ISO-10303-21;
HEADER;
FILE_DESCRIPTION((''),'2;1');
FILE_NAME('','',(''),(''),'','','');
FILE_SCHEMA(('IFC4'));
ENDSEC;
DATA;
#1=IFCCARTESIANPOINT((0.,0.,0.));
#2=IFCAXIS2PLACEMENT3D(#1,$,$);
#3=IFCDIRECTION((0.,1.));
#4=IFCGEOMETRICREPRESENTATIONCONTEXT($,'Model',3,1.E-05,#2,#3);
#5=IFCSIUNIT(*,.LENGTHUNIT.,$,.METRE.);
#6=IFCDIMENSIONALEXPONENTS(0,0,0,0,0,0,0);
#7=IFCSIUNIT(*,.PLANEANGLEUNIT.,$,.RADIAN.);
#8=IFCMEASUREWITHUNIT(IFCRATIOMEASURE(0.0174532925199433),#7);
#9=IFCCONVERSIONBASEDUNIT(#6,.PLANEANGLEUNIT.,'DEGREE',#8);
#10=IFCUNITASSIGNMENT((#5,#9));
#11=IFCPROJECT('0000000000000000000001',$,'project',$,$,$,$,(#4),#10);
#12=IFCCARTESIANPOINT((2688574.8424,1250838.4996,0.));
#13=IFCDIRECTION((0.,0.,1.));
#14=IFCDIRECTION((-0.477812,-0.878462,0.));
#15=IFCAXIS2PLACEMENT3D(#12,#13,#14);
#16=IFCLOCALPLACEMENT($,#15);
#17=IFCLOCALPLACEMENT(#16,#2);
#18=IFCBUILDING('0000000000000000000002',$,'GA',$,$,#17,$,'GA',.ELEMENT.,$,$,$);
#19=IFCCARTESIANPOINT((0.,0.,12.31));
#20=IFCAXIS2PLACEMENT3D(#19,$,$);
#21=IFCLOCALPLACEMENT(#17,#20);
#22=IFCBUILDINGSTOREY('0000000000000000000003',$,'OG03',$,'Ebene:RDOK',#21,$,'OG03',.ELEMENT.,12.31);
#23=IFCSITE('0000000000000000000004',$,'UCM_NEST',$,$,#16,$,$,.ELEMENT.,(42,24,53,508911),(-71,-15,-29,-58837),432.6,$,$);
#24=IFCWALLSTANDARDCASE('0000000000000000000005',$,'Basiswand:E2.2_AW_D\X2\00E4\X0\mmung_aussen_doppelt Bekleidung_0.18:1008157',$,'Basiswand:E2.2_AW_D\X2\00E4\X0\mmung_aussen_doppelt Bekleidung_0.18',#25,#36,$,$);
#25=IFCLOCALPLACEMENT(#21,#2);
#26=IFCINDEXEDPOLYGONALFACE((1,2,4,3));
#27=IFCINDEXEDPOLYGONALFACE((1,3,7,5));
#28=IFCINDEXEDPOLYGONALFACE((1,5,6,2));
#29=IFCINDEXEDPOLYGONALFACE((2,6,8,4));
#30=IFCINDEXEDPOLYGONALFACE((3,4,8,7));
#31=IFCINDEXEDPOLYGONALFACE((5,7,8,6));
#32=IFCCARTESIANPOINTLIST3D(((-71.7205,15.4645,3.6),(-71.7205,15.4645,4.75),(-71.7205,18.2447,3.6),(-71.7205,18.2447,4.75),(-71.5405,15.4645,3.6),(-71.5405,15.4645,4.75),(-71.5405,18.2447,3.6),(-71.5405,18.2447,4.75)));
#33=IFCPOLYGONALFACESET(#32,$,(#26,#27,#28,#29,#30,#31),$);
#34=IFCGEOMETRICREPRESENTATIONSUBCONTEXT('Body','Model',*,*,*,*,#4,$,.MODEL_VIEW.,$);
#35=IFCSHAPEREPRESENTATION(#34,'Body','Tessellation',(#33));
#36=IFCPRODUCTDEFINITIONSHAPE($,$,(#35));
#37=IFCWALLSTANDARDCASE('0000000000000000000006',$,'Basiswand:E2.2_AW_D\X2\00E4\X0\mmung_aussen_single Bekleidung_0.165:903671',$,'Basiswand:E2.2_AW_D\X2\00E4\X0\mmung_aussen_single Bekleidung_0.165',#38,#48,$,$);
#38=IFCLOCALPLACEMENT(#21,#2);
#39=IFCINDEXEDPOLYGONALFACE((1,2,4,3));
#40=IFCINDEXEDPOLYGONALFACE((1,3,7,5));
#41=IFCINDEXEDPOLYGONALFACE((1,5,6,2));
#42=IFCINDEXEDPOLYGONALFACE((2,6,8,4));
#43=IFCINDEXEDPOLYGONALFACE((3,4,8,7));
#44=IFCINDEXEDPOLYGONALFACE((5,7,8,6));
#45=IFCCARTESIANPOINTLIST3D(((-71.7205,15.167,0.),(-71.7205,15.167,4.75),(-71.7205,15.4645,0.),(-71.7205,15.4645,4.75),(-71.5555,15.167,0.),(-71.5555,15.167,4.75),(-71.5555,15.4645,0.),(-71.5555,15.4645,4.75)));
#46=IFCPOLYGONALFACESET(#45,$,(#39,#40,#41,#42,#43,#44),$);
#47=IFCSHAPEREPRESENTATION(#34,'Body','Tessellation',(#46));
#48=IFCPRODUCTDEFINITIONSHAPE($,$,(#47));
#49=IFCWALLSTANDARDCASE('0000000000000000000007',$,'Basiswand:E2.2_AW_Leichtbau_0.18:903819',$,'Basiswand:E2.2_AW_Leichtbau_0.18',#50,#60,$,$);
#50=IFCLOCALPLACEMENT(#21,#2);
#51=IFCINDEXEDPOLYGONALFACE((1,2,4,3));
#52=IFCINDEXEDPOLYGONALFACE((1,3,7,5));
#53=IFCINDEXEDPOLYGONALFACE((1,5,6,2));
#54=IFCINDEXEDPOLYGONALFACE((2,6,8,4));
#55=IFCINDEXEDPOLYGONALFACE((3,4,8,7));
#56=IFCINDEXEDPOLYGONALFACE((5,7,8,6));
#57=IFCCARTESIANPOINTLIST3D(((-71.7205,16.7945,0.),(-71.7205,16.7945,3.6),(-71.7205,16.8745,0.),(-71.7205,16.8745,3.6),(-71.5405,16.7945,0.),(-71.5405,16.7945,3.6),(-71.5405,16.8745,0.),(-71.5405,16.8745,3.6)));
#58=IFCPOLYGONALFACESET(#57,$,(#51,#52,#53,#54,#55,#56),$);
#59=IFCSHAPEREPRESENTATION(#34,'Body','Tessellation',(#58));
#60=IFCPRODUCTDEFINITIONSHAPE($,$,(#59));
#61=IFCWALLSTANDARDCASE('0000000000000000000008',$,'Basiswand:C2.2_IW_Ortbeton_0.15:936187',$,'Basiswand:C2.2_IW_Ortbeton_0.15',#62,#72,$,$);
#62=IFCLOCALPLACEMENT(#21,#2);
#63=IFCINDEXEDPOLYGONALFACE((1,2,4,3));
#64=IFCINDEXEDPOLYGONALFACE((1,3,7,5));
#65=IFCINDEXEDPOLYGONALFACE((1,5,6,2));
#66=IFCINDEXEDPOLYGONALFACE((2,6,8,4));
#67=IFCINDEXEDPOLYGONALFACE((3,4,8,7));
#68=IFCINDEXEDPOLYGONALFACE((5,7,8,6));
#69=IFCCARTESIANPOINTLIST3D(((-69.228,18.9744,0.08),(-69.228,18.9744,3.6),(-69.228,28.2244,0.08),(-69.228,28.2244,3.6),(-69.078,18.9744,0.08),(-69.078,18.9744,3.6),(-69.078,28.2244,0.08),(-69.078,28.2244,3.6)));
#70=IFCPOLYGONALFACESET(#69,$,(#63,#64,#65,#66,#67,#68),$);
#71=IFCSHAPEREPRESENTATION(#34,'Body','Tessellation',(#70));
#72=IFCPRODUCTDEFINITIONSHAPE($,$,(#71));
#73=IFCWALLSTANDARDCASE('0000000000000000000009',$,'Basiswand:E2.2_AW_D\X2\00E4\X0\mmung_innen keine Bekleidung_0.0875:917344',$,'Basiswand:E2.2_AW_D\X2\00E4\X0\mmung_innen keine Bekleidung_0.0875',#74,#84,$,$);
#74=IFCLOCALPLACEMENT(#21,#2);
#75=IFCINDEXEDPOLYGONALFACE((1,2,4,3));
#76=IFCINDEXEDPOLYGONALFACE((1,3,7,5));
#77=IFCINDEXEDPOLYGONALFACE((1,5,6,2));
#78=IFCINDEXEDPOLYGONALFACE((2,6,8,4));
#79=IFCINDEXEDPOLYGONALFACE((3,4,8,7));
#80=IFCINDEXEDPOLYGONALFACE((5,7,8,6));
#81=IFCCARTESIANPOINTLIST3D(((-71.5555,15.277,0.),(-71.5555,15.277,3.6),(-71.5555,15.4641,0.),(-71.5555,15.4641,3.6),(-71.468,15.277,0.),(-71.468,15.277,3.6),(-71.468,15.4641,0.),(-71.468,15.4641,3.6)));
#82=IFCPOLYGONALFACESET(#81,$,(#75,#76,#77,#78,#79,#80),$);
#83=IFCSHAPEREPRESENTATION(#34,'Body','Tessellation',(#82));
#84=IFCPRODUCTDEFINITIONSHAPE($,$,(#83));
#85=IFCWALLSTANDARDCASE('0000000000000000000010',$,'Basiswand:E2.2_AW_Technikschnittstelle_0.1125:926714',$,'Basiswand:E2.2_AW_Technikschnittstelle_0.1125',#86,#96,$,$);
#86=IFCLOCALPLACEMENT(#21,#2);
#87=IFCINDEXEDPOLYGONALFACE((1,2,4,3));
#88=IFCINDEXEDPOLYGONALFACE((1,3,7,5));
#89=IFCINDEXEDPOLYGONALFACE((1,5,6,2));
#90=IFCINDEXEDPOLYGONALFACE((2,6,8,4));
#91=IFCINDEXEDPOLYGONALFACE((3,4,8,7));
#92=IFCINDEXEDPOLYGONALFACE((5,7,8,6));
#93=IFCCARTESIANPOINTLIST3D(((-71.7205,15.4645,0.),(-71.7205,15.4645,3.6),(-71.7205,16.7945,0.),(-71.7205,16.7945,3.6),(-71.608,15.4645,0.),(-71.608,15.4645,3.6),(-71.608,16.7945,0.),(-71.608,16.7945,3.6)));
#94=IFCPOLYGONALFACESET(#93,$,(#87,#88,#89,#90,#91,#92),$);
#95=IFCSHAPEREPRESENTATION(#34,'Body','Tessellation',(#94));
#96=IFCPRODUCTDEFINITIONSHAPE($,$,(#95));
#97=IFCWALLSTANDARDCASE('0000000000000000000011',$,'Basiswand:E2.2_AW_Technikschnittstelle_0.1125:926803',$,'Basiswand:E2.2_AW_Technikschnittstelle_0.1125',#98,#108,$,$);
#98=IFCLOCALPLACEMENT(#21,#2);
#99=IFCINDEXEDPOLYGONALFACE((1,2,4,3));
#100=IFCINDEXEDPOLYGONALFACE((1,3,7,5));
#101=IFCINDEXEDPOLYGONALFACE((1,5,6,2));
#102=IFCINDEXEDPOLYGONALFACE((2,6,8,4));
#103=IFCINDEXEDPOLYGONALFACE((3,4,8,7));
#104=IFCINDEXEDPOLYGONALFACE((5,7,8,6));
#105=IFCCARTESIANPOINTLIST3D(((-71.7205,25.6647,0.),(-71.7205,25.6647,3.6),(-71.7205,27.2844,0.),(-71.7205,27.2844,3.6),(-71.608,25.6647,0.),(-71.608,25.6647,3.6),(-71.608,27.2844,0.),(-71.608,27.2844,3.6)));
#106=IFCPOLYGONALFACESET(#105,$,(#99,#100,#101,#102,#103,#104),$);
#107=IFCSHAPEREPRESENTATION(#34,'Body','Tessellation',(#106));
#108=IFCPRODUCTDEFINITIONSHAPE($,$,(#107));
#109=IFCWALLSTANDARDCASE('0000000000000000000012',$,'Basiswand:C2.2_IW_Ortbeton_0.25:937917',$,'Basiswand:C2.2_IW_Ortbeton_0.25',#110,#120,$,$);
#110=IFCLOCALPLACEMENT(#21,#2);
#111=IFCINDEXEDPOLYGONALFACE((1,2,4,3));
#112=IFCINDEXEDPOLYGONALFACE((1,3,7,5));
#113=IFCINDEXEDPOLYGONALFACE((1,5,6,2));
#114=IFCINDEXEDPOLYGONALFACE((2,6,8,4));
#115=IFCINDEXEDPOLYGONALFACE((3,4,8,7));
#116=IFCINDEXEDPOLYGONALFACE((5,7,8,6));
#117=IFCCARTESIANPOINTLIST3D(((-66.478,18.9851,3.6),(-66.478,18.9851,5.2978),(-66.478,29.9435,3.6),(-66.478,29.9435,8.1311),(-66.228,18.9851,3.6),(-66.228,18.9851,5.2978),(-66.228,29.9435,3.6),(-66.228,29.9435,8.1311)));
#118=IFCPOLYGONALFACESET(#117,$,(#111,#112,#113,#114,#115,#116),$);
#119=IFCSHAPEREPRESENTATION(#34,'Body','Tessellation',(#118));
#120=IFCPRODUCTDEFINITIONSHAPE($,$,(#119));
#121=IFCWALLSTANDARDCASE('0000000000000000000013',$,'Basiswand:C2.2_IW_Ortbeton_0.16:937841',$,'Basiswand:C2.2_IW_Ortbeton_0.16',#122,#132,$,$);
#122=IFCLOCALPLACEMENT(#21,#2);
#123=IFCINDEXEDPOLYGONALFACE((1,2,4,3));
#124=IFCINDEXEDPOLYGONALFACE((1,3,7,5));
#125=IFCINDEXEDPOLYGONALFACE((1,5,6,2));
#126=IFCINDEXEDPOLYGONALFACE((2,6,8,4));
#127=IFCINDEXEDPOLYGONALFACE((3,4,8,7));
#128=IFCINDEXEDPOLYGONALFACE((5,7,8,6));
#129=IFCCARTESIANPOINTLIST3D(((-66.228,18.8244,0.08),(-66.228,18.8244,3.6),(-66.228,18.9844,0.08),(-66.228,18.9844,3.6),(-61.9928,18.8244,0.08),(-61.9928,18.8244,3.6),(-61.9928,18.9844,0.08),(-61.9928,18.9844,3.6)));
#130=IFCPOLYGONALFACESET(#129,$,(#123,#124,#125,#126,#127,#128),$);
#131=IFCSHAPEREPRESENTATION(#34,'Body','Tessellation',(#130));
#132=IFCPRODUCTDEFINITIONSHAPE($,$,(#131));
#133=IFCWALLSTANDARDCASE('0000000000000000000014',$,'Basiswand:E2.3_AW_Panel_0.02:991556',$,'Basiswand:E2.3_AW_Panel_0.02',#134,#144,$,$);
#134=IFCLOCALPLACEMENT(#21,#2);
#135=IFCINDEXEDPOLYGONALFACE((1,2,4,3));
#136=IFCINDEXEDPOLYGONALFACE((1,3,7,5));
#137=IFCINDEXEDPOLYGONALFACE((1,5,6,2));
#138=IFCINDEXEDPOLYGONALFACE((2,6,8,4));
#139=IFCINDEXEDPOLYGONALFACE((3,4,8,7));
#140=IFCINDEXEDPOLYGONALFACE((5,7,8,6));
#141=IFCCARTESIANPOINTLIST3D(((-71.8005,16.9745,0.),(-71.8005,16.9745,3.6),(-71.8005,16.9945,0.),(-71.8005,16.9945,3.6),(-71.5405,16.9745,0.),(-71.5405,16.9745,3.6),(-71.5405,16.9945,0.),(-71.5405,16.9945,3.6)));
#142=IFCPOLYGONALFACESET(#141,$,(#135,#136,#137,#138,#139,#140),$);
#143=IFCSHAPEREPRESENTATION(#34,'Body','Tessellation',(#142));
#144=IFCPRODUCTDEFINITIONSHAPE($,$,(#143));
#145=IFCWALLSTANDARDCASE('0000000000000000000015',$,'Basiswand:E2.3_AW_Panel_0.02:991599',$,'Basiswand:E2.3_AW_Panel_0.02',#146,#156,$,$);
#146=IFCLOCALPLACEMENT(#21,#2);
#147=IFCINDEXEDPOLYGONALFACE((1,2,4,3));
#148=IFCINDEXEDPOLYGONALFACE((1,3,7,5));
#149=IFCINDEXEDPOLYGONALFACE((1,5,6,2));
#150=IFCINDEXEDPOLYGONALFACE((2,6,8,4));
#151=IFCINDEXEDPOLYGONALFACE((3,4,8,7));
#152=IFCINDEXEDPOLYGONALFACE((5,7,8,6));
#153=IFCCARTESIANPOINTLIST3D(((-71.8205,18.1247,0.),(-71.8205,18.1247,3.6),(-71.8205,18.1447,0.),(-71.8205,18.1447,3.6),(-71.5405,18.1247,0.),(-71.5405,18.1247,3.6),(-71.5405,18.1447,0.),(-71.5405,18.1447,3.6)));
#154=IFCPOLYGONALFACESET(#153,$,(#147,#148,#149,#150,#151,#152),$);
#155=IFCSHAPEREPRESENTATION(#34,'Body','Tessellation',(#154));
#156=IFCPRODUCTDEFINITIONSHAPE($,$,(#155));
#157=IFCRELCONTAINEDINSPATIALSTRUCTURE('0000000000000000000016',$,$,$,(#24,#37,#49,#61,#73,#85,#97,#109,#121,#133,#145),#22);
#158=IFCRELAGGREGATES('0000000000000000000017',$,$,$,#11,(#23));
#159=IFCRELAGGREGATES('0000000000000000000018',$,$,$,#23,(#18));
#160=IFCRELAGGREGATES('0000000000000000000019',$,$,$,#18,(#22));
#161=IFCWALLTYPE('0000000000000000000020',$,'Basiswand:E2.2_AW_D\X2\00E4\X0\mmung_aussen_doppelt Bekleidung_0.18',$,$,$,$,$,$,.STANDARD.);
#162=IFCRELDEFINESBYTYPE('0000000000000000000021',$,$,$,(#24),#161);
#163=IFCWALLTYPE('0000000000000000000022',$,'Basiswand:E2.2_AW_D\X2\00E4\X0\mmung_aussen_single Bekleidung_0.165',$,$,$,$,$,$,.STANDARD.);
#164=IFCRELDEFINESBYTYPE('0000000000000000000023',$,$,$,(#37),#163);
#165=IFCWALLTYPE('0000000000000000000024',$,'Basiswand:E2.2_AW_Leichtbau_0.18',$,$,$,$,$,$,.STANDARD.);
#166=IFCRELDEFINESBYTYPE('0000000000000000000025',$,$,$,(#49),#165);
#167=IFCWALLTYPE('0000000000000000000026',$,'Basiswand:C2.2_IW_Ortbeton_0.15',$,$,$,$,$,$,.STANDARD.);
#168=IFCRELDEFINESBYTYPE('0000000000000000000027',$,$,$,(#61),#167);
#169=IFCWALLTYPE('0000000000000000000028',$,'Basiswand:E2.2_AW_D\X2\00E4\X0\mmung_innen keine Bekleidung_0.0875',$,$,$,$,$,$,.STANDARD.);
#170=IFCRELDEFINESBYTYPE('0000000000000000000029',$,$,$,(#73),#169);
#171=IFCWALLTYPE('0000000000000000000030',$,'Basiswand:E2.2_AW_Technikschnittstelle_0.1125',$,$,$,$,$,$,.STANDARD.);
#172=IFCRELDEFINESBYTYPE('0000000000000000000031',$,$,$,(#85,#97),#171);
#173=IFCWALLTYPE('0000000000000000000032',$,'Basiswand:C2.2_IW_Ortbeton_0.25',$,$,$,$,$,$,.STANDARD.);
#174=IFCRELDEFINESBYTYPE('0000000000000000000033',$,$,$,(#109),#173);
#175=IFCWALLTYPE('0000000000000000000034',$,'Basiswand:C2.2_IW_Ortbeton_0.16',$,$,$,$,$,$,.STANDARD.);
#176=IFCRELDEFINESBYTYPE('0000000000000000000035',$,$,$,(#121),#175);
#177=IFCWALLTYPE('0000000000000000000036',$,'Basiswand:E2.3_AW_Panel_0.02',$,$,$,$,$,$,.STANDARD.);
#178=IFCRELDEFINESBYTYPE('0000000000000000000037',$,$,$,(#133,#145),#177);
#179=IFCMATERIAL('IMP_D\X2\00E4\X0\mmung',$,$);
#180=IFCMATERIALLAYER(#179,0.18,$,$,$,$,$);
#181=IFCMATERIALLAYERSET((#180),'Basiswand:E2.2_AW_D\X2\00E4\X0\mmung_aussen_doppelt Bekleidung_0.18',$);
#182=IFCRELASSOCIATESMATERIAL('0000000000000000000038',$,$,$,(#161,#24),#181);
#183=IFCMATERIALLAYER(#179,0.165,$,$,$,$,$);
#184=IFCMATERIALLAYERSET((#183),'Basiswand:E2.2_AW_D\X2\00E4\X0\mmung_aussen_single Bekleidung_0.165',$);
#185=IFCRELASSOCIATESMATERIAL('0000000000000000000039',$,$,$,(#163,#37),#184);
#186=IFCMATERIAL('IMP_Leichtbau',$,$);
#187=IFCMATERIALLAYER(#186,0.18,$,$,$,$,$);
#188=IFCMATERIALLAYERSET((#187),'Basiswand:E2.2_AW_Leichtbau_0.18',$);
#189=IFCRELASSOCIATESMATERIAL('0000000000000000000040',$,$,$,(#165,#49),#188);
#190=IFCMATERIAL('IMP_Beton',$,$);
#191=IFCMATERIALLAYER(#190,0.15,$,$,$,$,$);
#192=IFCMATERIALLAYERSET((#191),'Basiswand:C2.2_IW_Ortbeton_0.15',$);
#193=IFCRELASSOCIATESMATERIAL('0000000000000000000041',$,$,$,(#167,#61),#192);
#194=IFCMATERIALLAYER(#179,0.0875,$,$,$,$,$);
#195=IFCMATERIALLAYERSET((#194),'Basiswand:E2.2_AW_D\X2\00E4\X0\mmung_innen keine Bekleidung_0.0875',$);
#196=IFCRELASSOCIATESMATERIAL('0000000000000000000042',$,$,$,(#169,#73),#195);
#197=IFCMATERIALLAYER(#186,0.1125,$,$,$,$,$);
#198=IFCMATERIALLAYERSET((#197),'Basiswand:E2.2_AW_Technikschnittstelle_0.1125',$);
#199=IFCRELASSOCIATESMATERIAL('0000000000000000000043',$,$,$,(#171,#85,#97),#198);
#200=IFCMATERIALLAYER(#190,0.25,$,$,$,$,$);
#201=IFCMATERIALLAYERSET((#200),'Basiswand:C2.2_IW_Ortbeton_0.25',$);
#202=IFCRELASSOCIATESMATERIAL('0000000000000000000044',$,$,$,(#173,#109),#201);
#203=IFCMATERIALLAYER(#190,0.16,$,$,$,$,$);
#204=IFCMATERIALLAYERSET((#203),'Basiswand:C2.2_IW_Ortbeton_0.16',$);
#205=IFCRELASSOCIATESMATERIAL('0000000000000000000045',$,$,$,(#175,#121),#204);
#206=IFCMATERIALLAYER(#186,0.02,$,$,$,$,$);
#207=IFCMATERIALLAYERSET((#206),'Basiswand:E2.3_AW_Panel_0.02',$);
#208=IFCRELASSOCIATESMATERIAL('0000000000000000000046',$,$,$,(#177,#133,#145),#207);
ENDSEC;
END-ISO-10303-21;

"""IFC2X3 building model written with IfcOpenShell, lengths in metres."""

from ifc_helpers import new_model, entity, si_unit, converted_unit, direction, frame, frame_2d, origin, place, context, subcontext, project, spatial, polyline, rectangle, extrude, clip, halfspace, bounded_halfspace, material, layer, layer_set, layer_usage, type_object, element, save


model = new_model("IFC2X3")

# Units and contexts
model_context = context("Model", 3, precision=1e-05, world=origin(), true_north=direction((0.0, 1.0)))
body_context = subcontext(model_context, "Body", "Model", "MODEL_VIEW")
ifc_project = project(units=[si_unit("LENGTHUNIT", "METRE"), converted_unit("PLANEANGLEUNIT", "DEGREE", entity("IfcRatioMeasure", 0.0174532925199433), si_unit("PLANEANGLEUNIT", "RADIAN"), dimensions=[0, 0, 0, 0, 0, 0, 0])], contexts=[model_context])

# Site, building, storey
site_placement = place(None, frame((2688574.8424, 1250838.4996, 0.0), z_axis=(0.0, 0.0, 1.0), x_axis=(-0.477812, -0.878462, 0.0)))
site = spatial("IfcSite", under=ifc_project, at=site_placement, Name="UCM_NEST", CompositionType="ELEMENT", RefLatitude=(42, 24, 53, 508911), RefLongitude=(-71, -15, -29, -58837), RefElevation=432.6)
building_placement = place(site_placement, origin())
building = spatial("IfcBuilding", under=site, at=building_placement, Name="GA", LongName="GA", CompositionType="ELEMENT")
storey_placement = place(building_placement, frame((0.0, 0.0, 12.31)))
storey = spatial("IfcBuildingStorey", under=building, at=storey_placement, Name="OG03", ObjectType="Ebene:RDOK", LongName="OG03", CompositionType="ELEMENT", Elevation=12.31)

# Shared definitions
ifc_material_1 = material(Name="IMP_Dämmung")
ifc_layer_1 = layer(ifc_material_1, 0.18)
ifc_layer_set_1 = layer_set([ifc_layer_1], Name="Basiswand:E2.2_AW_Dämmung_aussen_doppelt Bekleidung_0.18")
wall_type_1 = type_object("IfcWallType", Name="Basiswand:E2.2_AW_Dämmung_aussen_doppelt Bekleidung_0.18", PredefinedType="STANDARD", material=ifc_layer_set_1)

# Walls
ifc_layer_usage_1 = layer_usage(ifc_layer_set_1, "AXIS2", "NEGATIVE", 0.09)
wall_1_placement = place(storey_placement, frame((-71.6305, 18.2447, 3.6), z_axis=(0.0, 0.0, 1.0), x_axis=(0.0, -1.0, 0.0)))
element("IfcWallStandardCase", 1, at=wall_1_placement, inside=storey, type_object=wall_type_1, material=ifc_layer_usage_1, Name="Basiswand:E2.2_AW_Dämmung_aussen_doppelt Bekleidung_0.18:1008157", ObjectType="Basiswand:E2.2_AW_Dämmung_aussen_doppelt Bekleidung_0.18", context=body_context, shape_type="SweptSolid", body=[
    extrude(rectangle(XDim=2.7802, YDim=0.18, at=frame_2d((1.3901, 0.0), x_axis=(-1.0, 0.0))), origin(), (0.0, 0.0, 1.0), 1.15),
])
ifc_layer_2 = layer(ifc_material_1, 0.165)
ifc_layer_set_2 = layer_set([ifc_layer_2], Name="Basiswand:E2.2_AW_Dämmung_aussen_single Bekleidung_0.165")
ifc_layer_usage_2 = layer_usage(ifc_layer_set_2, "AXIS2", "NEGATIVE", 0.0825)
wall_type_2 = type_object("IfcWallType", Name="Basiswand:E2.2_AW_Dämmung_aussen_single Bekleidung_0.165", PredefinedType="STANDARD", material=ifc_layer_set_2)
wall_2_placement = place(storey_placement, frame((-71.638, 15.167, 0.0), z_axis=(0.0, 0.0, 1.0), x_axis=(0.0, 1.0, 0.0)))
element("IfcWallStandardCase", 2, at=wall_2_placement, inside=storey, type_object=wall_type_2, material=ifc_layer_usage_2, Name="Basiswand:E2.2_AW_Dämmung_aussen_single Bekleidung_0.165:903671", ObjectType="Basiswand:E2.2_AW_Dämmung_aussen_single Bekleidung_0.165", context=body_context, shape_type="SweptSolid", body=[
    extrude(rectangle(XDim=0.2975, YDim=0.165, at=frame_2d((0.1488, 0.0), x_axis=(-1.0, 0.0))), origin(), (0.0, 0.0, 1.0), 4.75),
])
ifc_material_2 = material(Name="IMP_Leichtbau")
ifc_layer_3 = layer(ifc_material_2, 0.18)
ifc_layer_set_3 = layer_set([ifc_layer_3], Name="Basiswand:E2.2_AW_Leichtbau_0.18")
ifc_layer_usage_3 = layer_usage(ifc_layer_set_3, "AXIS2", "NEGATIVE", 0.09)
wall_type_3 = type_object("IfcWallType", Name="Basiswand:E2.2_AW_Leichtbau_0.18", PredefinedType="STANDARD", material=ifc_layer_set_3)
wall_3_placement = place(storey_placement, frame((-71.6305, 16.7945, 0.0), z_axis=(0.0, 0.0, 1.0), x_axis=(0.0, 1.0, 0.0)))
element("IfcWallStandardCase", 3, at=wall_3_placement, inside=storey, type_object=wall_type_3, material=ifc_layer_usage_3, Name="Basiswand:E2.2_AW_Leichtbau_0.18:903819", ObjectType="Basiswand:E2.2_AW_Leichtbau_0.18", context=body_context, shape_type="SweptSolid", body=[
    extrude(rectangle(XDim=0.08, YDim=0.18, at=frame_2d((0.04, 0.0), x_axis=(-1.0, 0.0))), origin(), (0.0, 0.0, 1.0), 3.6),
])

# Shared definitions
ifc_material_3 = material(Name="IMP_Beton")
ifc_layer_4 = layer(ifc_material_3, 0.15)
ifc_layer_set_4 = layer_set([ifc_layer_4], Name="Basiswand:C2.2_IW_Ortbeton_0.15")
wall_type_4 = type_object("IfcWallType", Name="Basiswand:C2.2_IW_Ortbeton_0.15", PredefinedType="STANDARD", material=ifc_layer_set_4)

# Wall
ifc_layer_usage_4 = layer_usage(ifc_layer_set_4, "AXIS2", "NEGATIVE", 0.075)
wall_4_placement = place(storey_placement, frame((-69.153, 18.9744, 0.08), z_axis=(0.0, 0.0, 1.0), x_axis=(0.0, 1.0, 0.0)))
element("IfcWallStandardCase", 4, at=wall_4_placement, inside=storey, type_object=wall_type_4, material=ifc_layer_usage_4, Name="Basiswand:C2.2_IW_Ortbeton_0.15:936187", ObjectType="Basiswand:C2.2_IW_Ortbeton_0.15", context=body_context, shape_type="Clipping", body=[
    clip(extrude(rectangle(XDim=9.25, YDim=0.15, at=frame_2d((4.625, 0.0), x_axis=(-1.0, 0.0))), origin(), (0.0, 0.0, 1.0), 3.52), bounded_halfspace(frame((9.25, -0.075, 0.0), z_axis=(0.0, 0.0, 1.0), x_axis=(0.0, 1.0, 0.0)), True, frame((9.25, -0.075, 0.0), z_axis=(0.0, 0.0, 1.0), x_axis=(0.0, 1.0, 0.0)), polyline([(0.0, 0.0), (0.15, 0.0), (0.15, 0.15), (0.15, 9.25), (0.0, 9.25), (0.0, 0.0)]))),
])

# Walls
ifc_layer_5 = layer(ifc_material_1, 0.0875)
ifc_layer_set_5 = layer_set([ifc_layer_5], Name="Basiswand:E2.2_AW_Dämmung_innen keine Bekleidung_0.0875")
ifc_layer_usage_5 = layer_usage(ifc_layer_set_5, "AXIS2", "NEGATIVE", 0.0437)
wall_type_5 = type_object("IfcWallType", Name="Basiswand:E2.2_AW_Dämmung_innen keine Bekleidung_0.0875", PredefinedType="STANDARD", material=ifc_layer_set_5)
wall_5_placement = place(storey_placement, frame((-71.5118, 15.4641, 0.0), z_axis=(0.0, 0.0, 1.0), x_axis=(0.0, -1.0, 0.0)))
element("IfcWallStandardCase", 5, at=wall_5_placement, inside=storey, type_object=wall_type_5, material=ifc_layer_usage_5, Name="Basiswand:E2.2_AW_Dämmung_innen keine Bekleidung_0.0875:917344", ObjectType="Basiswand:E2.2_AW_Dämmung_innen keine Bekleidung_0.0875", context=body_context, shape_type="SweptSolid", body=[
    extrude(rectangle(XDim=0.1872, YDim=0.0875, at=frame_2d((0.0936, 0.0), x_axis=(-1.0, 0.0))), origin(), (0.0, 0.0, 1.0), 3.6),
])
ifc_layer_6 = layer(ifc_material_2, 0.1125)
ifc_layer_set_6 = layer_set([ifc_layer_6], Name="Basiswand:E2.2_AW_Technikschnittstelle_0.1125")
ifc_layer_usage_6 = layer_usage(ifc_layer_set_6, "AXIS2", "NEGATIVE", 0.0563)
wall_type_6 = type_object("IfcWallType", Name="Basiswand:E2.2_AW_Technikschnittstelle_0.1125", PredefinedType="STANDARD", material=ifc_layer_set_6)
wall_6_placement = place(storey_placement, frame((-71.6642, 15.4645, 0.0), z_axis=(0.0, 0.0, 1.0), x_axis=(0.0, 1.0, 0.0)))
element("IfcWallStandardCase", 6, at=wall_6_placement, inside=storey, type_object=wall_type_6, material=ifc_layer_usage_6, Name="Basiswand:E2.2_AW_Technikschnittstelle_0.1125:926714", ObjectType="Basiswand:E2.2_AW_Technikschnittstelle_0.1125", context=body_context, shape_type="SweptSolid", body=[
    extrude(rectangle(XDim=1.3299, YDim=0.1125, at=frame_2d((0.665, 0.0), x_axis=(-1.0, 0.0))), origin(), (0.0, 0.0, 1.0), 3.6),
])
ifc_layer_usage_7 = layer_usage(ifc_layer_set_6, "AXIS2", "NEGATIVE", 0.0563)
wall_7_placement = place(storey_placement, frame((-71.6642, 25.6647, 0.0), z_axis=(0.0, 0.0, 1.0), x_axis=(0.0, 1.0, 0.0)))
element("IfcWallStandardCase", 7, at=wall_7_placement, inside=storey, type_object=wall_type_6, material=ifc_layer_usage_7, Name="Basiswand:E2.2_AW_Technikschnittstelle_0.1125:926803", ObjectType="Basiswand:E2.2_AW_Technikschnittstelle_0.1125", context=body_context, shape_type="SweptSolid", body=[
    extrude(rectangle(XDim=1.6197, YDim=0.1125, at=frame_2d((0.8099, 0.0), x_axis=(-1.0, 0.0))), origin(), (0.0, 0.0, 1.0), 3.6),
])

# Shared definitions
ifc_layer_7 = layer(ifc_material_3, 0.25)
ifc_layer_set_7 = layer_set([ifc_layer_7], Name="Basiswand:C2.2_IW_Ortbeton_0.25")
wall_type_7 = type_object("IfcWallType", Name="Basiswand:C2.2_IW_Ortbeton_0.25", PredefinedType="STANDARD", material=ifc_layer_set_7)

# Wall
ifc_layer_usage_8 = layer_usage(ifc_layer_set_7, "AXIS2", "NEGATIVE", 0.125)
wall_8_placement = place(storey_placement, frame((-66.353, 18.9851, 3.6), z_axis=(0.0, 0.0, 1.0), x_axis=(0.0, 1.0, 0.0)))
element("IfcWallStandardCase", 8, at=wall_8_placement, inside=storey, type_object=wall_type_7, material=ifc_layer_usage_8, Name="Basiswand:C2.2_IW_Ortbeton_0.25:937917", ObjectType="Basiswand:C2.2_IW_Ortbeton_0.25", context=body_context, shape_type="Clipping", body=[
    clip(extrude(rectangle(XDim=10.9584, YDim=0.25, at=frame_2d((5.4792, 0.0), x_axis=(-1.0, 0.0))), origin(), (0.0, 0.0, 1.0), 4.5311), halfspace(frame((0.0, -0.125, 1.6978), z_axis=(-0.250322, 0.0, 0.968163), x_axis=(0.0, 1.0, 0.0)), False)),
])

# Shared definitions
ifc_layer_8 = layer(ifc_material_3, 0.16)
ifc_layer_set_8 = layer_set([ifc_layer_8], Name="Basiswand:C2.2_IW_Ortbeton_0.16")
wall_type_8 = type_object("IfcWallType", Name="Basiswand:C2.2_IW_Ortbeton_0.16", PredefinedType="STANDARD", material=ifc_layer_set_8)

# Walls
ifc_layer_usage_9 = layer_usage(ifc_layer_set_8, "AXIS2", "NEGATIVE", 0.08)
wall_9_placement = place(storey_placement, frame((-66.228, 18.9044, 0.08)))
element("IfcWallStandardCase", 9, at=wall_9_placement, inside=storey, type_object=wall_type_8, material=ifc_layer_usage_9, Name="Basiswand:C2.2_IW_Ortbeton_0.16:937841", ObjectType="Basiswand:C2.2_IW_Ortbeton_0.16", context=body_context, shape_type="Clipping", body=[
    clip(clip(extrude(rectangle(XDim=4.2352, YDim=0.16, at=frame_2d((2.1176, 0.0), x_axis=(-1.0, 0.0))), origin(), (0.0, 0.0, 1.0), 3.52), bounded_halfspace(frame((4.2352, -0.08, 0.0), z_axis=(0.0, 0.0, 1.0), x_axis=(-1.0, 0.0, 0.0)), True, frame((4.2352, -0.08, 0.0), z_axis=(0.0, 0.0, 1.0), x_axis=(-1.0, 0.0, 0.0)), polyline([(0.0, 0.0), (0.0, -0.16), (4.2352, -0.16), (4.2352, 0.0), (0.0, 0.0)]))), bounded_halfspace(frame((0.0, -0.08, 3.52), z_axis=(0.0, 0.0, -1.0), x_axis=(0.0, 1.0, 0.0)), True, frame((0.0, -0.08, 3.52), z_axis=(0.0, 0.0, -1.0), x_axis=(0.0, 1.0, 0.0)), polyline([(0.0, 0.0), (0.16, 0.0), (0.16, 4.2352), (0.0, 4.2352), (0.0, 0.0)]))),
])
ifc_layer_9 = layer(ifc_material_2, 0.02)
ifc_layer_set_9 = layer_set([ifc_layer_9], Name="Basiswand:E2.3_AW_Panel_0.02")
ifc_layer_usage_10 = layer_usage(ifc_layer_set_9, "AXIS2", "NEGATIVE", 0.01)
wall_type_9 = type_object("IfcWallType", Name="Basiswand:E2.3_AW_Panel_0.02", PredefinedType="STANDARD", material=ifc_layer_set_9)
wall_10_placement = place(storey_placement, frame((-71.8005, 16.9845, 0.0)))
element("IfcWallStandardCase", 10, at=wall_10_placement, inside=storey, type_object=wall_type_9, material=ifc_layer_usage_10, Name="Basiswand:E2.3_AW_Panel_0.02:991556", ObjectType="Basiswand:E2.3_AW_Panel_0.02", context=body_context, shape_type="SweptSolid", body=[
    extrude(rectangle(XDim=0.26, YDim=0.02, at=frame_2d((0.13, 0.0), x_axis=(-1.0, 0.0))), origin(), (0.0, 0.0, 1.0), 3.6),
])
ifc_layer_usage_11 = layer_usage(ifc_layer_set_9, "AXIS2", "NEGATIVE", 0.01)
wall_11_placement = place(storey_placement, frame((-71.5405, 18.1347, 0.0), z_axis=(0.0, 0.0, 1.0), x_axis=(-1.0, 0.0, 0.0)))
element("IfcWallStandardCase", 11, at=wall_11_placement, inside=storey, type_object=wall_type_9, material=ifc_layer_usage_11, Name="Basiswand:E2.3_AW_Panel_0.02:991599", ObjectType="Basiswand:E2.3_AW_Panel_0.02", context=body_context, shape_type="SweptSolid", body=[
    extrude(rectangle(XDim=0.28, YDim=0.02, at=frame_2d((0.14, 0.0), x_axis=(-1.0, 0.0))), origin(), (0.0, 0.0, 1.0), 3.6),
])

save(model, "model.ifc")
